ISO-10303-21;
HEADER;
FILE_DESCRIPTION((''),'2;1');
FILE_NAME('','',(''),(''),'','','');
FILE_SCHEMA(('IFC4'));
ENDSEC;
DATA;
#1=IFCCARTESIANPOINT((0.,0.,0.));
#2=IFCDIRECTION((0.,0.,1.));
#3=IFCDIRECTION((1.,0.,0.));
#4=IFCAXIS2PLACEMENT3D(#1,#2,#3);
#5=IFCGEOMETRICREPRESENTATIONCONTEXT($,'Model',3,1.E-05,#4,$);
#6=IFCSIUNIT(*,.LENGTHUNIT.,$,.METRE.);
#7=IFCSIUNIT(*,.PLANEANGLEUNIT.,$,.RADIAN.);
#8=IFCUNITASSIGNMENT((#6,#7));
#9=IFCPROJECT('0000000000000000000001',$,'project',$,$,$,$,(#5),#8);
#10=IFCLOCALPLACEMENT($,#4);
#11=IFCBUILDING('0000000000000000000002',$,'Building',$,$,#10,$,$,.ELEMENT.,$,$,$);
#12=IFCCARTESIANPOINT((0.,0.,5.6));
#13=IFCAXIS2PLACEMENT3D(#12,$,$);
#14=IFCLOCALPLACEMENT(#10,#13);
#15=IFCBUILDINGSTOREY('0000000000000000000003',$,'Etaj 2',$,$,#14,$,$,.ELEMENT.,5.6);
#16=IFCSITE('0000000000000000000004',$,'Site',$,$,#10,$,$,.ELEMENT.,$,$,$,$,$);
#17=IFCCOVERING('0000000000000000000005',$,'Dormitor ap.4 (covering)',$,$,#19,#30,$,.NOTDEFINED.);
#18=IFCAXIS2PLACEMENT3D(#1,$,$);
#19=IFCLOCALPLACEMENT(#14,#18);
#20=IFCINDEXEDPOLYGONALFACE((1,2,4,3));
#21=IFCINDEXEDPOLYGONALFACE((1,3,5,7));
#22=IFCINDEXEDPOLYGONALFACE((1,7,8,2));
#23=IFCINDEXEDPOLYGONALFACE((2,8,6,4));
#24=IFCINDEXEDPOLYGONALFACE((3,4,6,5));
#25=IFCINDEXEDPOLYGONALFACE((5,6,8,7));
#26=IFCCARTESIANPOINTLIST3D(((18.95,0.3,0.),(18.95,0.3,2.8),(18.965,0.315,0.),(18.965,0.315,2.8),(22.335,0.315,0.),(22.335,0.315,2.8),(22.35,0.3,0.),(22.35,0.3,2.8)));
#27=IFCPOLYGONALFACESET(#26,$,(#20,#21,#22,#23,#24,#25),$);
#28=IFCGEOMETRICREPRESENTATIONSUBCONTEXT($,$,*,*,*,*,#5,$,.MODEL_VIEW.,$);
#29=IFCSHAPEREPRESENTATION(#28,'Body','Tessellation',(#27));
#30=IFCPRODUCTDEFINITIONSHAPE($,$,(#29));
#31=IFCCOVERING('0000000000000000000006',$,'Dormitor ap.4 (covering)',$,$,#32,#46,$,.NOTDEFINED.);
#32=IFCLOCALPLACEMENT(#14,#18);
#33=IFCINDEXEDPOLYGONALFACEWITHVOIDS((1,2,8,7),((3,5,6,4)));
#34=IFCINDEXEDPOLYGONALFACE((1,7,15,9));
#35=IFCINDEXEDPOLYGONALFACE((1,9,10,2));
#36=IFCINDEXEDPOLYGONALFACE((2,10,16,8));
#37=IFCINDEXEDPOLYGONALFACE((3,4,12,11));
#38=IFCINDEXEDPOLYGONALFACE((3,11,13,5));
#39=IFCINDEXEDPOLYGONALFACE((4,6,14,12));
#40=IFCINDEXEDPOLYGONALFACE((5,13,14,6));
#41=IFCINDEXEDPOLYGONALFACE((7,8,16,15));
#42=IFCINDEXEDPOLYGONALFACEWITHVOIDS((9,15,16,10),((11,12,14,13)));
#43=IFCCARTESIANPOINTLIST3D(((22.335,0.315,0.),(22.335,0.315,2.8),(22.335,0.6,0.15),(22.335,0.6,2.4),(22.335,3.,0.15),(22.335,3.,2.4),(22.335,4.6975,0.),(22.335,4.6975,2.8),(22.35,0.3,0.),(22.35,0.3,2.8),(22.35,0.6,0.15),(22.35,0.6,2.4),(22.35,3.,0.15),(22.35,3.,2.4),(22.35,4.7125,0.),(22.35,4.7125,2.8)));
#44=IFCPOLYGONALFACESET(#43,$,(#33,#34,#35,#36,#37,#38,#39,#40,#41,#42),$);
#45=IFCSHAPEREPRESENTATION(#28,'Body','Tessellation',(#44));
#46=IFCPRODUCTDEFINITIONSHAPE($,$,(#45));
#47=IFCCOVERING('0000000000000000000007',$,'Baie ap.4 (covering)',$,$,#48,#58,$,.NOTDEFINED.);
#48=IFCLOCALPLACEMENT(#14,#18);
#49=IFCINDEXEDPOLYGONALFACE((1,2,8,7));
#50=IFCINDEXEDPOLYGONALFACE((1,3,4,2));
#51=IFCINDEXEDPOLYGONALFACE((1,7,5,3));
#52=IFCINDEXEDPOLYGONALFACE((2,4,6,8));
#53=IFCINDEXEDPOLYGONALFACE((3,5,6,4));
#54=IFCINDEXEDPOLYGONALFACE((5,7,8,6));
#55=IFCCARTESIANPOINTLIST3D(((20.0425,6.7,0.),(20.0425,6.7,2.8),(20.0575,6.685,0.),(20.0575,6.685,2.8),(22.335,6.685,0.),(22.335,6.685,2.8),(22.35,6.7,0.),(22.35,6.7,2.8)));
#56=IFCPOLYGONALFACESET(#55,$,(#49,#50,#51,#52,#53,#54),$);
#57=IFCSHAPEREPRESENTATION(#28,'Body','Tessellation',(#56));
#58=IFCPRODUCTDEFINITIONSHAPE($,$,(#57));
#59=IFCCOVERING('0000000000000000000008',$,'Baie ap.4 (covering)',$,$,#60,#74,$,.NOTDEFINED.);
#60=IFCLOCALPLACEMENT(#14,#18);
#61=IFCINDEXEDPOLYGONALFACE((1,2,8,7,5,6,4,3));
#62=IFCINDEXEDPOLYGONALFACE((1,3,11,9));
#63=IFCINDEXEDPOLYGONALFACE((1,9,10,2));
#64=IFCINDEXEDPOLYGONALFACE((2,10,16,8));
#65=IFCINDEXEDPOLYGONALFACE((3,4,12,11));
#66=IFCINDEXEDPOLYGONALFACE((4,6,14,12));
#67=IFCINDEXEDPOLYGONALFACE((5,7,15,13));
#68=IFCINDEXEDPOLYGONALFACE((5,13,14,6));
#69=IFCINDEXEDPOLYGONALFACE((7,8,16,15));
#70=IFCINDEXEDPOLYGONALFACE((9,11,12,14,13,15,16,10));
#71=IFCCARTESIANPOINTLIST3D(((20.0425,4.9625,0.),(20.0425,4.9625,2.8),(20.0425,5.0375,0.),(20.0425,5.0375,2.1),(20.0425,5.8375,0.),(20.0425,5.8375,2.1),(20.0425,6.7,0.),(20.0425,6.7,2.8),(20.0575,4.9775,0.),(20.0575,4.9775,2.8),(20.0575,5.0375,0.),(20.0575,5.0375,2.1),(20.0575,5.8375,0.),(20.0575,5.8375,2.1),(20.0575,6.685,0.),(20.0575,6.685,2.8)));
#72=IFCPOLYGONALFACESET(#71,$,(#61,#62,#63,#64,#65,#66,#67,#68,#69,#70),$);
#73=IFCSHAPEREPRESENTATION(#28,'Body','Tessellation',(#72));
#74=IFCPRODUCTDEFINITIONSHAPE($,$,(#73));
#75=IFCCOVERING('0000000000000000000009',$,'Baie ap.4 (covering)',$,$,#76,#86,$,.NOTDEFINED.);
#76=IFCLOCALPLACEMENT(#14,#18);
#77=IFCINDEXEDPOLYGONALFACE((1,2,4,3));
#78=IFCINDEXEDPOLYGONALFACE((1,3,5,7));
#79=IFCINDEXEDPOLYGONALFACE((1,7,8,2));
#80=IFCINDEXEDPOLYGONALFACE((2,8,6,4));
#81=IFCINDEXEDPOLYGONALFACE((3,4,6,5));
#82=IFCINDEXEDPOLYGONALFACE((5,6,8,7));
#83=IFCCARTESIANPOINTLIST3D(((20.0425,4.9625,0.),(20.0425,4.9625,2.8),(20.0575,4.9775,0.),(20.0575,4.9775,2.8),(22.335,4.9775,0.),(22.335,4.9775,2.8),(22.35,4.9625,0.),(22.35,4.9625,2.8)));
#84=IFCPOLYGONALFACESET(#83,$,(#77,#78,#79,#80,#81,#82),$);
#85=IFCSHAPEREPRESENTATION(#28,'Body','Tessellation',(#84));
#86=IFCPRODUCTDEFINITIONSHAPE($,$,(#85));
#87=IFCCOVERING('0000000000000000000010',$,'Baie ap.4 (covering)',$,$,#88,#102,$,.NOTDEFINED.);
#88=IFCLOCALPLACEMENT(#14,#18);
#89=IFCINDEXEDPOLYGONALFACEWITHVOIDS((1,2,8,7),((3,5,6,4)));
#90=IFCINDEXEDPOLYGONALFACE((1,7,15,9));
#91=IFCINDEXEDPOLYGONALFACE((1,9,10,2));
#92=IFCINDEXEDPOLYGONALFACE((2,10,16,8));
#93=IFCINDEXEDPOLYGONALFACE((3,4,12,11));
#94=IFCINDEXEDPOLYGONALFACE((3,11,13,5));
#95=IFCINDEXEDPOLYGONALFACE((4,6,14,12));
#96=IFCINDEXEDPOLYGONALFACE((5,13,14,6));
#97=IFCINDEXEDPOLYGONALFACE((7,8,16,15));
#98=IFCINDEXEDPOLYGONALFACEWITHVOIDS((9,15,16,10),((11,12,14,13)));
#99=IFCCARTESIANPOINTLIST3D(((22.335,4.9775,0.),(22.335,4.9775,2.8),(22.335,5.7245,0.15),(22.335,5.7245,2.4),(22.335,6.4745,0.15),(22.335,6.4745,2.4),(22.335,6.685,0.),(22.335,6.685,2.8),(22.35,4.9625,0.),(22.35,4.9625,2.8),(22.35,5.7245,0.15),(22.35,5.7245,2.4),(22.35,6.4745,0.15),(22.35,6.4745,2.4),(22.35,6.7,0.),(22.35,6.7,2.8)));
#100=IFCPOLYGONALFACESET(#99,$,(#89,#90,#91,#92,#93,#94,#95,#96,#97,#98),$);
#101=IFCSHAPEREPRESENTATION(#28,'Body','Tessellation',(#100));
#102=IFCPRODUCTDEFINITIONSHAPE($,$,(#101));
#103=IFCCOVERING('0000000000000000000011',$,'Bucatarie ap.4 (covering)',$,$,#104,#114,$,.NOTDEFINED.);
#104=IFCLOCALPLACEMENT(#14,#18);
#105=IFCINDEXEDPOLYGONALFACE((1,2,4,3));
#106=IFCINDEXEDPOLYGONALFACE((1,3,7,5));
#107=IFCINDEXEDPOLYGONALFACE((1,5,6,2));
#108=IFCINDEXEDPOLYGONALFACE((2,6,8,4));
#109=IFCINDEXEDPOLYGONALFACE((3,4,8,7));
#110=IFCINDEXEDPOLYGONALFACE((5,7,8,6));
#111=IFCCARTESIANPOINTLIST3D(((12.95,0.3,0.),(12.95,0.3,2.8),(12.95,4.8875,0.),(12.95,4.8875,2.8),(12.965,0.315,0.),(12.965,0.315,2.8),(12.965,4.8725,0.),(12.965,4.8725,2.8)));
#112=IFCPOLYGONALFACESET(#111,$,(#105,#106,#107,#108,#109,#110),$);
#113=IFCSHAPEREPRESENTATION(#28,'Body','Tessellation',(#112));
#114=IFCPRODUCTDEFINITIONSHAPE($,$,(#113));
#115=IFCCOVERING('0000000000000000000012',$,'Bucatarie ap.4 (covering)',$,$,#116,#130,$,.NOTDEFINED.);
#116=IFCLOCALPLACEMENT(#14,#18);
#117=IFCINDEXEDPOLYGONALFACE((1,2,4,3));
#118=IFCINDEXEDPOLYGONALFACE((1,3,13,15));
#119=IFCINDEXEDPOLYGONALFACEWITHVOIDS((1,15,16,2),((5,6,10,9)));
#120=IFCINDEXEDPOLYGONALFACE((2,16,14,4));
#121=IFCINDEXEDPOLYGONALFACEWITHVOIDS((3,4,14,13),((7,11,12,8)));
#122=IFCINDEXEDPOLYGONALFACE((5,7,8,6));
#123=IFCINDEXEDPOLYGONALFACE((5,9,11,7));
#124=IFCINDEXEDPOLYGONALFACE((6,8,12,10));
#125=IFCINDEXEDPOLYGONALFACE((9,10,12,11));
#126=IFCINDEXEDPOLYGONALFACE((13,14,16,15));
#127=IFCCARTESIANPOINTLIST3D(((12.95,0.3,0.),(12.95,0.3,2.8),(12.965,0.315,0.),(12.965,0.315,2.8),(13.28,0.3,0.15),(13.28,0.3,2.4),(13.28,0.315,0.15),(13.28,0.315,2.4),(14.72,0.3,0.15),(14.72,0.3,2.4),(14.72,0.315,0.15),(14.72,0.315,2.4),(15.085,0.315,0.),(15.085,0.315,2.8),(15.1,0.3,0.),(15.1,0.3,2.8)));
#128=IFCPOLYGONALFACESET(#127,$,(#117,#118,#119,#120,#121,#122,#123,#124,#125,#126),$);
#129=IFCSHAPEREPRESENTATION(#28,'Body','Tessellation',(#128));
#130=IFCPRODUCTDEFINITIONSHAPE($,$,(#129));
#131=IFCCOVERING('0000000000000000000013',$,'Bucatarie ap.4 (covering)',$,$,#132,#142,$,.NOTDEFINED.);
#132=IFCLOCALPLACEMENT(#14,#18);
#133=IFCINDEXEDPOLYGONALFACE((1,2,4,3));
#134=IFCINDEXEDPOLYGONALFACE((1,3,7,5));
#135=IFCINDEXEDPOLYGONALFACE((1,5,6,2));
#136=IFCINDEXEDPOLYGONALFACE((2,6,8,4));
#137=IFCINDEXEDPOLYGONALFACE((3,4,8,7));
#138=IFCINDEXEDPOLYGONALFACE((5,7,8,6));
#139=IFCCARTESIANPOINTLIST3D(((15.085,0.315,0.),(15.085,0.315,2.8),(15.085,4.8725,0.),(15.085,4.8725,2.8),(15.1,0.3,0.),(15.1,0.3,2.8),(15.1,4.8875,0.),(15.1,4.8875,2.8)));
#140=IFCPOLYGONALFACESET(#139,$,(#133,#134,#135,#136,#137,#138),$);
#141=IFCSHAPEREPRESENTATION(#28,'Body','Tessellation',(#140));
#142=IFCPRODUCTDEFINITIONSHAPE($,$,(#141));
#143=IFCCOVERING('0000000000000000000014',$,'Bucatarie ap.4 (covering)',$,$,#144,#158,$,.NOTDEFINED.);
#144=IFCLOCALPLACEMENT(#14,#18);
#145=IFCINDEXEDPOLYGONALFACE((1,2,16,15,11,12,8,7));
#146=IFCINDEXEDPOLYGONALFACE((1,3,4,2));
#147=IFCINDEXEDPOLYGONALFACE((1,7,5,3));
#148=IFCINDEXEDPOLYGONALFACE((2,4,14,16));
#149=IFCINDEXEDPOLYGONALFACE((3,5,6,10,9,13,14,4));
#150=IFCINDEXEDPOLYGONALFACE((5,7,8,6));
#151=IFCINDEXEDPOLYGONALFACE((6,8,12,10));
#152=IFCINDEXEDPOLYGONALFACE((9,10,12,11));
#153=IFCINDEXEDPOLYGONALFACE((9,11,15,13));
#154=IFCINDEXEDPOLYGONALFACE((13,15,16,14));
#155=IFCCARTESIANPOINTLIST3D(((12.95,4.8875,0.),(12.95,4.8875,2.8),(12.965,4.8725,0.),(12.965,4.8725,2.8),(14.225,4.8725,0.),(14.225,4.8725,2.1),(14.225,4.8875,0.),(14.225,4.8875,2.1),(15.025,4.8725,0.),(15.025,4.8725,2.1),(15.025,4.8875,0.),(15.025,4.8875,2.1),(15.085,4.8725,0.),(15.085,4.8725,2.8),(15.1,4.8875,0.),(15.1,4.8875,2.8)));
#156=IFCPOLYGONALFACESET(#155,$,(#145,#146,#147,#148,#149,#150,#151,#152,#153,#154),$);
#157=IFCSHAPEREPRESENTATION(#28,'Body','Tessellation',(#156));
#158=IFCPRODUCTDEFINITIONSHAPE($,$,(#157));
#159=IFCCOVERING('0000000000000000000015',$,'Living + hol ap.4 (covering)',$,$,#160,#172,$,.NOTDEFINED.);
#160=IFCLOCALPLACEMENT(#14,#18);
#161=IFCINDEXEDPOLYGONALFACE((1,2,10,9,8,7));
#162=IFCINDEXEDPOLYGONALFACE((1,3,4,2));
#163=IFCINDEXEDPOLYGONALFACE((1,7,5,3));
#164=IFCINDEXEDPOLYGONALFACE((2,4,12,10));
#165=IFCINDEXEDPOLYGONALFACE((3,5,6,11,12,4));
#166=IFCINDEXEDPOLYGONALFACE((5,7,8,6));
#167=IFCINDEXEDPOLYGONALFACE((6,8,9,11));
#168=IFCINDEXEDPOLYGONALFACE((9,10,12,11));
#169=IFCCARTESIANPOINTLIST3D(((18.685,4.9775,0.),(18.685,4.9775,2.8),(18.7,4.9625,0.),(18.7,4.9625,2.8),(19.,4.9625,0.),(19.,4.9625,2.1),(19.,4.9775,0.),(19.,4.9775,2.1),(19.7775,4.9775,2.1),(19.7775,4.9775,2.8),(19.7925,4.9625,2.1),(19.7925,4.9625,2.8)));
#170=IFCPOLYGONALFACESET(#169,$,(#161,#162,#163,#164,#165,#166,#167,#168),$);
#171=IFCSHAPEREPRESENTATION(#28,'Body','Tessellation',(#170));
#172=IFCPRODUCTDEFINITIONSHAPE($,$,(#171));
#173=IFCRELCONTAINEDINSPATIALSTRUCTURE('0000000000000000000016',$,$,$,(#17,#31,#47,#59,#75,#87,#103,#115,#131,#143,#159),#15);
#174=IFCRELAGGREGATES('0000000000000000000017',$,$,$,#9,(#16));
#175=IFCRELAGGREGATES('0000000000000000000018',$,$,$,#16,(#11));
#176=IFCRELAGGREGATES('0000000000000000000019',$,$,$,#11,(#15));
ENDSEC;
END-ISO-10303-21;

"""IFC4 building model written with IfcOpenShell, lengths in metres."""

from ifc_helpers import new_model, si_unit, frame, origin, origin_with_axes, origin_2d, place, context, subcontext, project, spatial, polyline, rectangle, outline, extrude, element, save


model = new_model("IFC4")

# Units and contexts
model_context = context("Model", 3, precision=1e-05, world=origin_with_axes())
sub_context = subcontext(model_context, None, None, "MODEL_VIEW")
ifc_project = project(units=[si_unit("LENGTHUNIT", "METRE"), si_unit("PLANEANGLEUNIT", "RADIAN")], contexts=[model_context])

# Site, building, storey
placement = place(None, origin_with_axes())
site = spatial("IfcSite", under=ifc_project, at=placement, Name="Site", CompositionType="ELEMENT")
building = spatial("IfcBuilding", under=site, at=placement, Name="Building", CompositionType="ELEMENT")
storey_placement = place(placement, frame((0.0, 0.0, 5.6)))
storey = spatial("IfcBuildingStorey", under=building, at=storey_placement, Name="Etaj 2", CompositionType="ELEMENT", Elevation=5.6)

# Covering
covering_1_placement = place(storey_placement, origin_with_axes())
element("IfcCovering", 1, at=covering_1_placement, inside=storey, Name="Dormitor ap.4 (covering)", PredefinedType="NOTDEFINED", context=sub_context, shape_type="SweptSolid", body=[
    extrude(outline(polyline([(18.95, 0.3), (22.35, 0.3), (22.335, 0.315), (18.965, 0.315), (18.95, 0.3)])), origin(), (0.0, 0.0, 1.0), 2.8),
])

# Covering, opening
covering_2_placement = place(storey_placement, origin_with_axes())
covering_2 = element("IfcCovering", 2, at=covering_2_placement, inside=storey, Name="Dormitor ap.4 (covering)", PredefinedType="NOTDEFINED", context=sub_context, shape_type="SweptSolid", body=[
    extrude(outline(polyline([(22.35, 0.3), (22.35, 4.7125), (22.335, 4.6975), (22.335, 0.315), (22.35, 0.3)])), origin(), (0.0, 0.0, 1.0), 2.8),
])
opening_1_placement = place(covering_2_placement, frame((22.285, 1.8, 0.15), z_axis=(1.0, 0.0, 0.0), x_axis=(0.0, 1.0, 0.0)))
element("IfcOpeningElement", 3, at=opening_1_placement, cuts=covering_2, PredefinedType="OPENING", context=sub_context, shape_type="SweptSolid", body=[
    extrude(rectangle(XDim=2.4, YDim=2.25, at=origin_2d()), frame((0.0, 1.125, 0.0)), (0.0, 0.0, 1.0), 0.38),
])

# Covering
covering_3_placement = place(storey_placement, origin_with_axes())
element("IfcCovering", 4, at=covering_3_placement, inside=storey, Name="Baie ap.4 (covering)", PredefinedType="NOTDEFINED", context=sub_context, shape_type="SweptSolid", body=[
    extrude(outline(polyline([(22.35, 6.7), (20.0425, 6.7), (20.0575, 6.685), (22.335, 6.685), (22.35, 6.7)])), origin(), (0.0, 0.0, 1.0), 2.8),
])

# Covering, opening
covering_4_placement = place(storey_placement, origin_with_axes())
covering_4 = element("IfcCovering", 5, at=covering_4_placement, inside=storey, Name="Baie ap.4 (covering)", PredefinedType="NOTDEFINED", context=sub_context, shape_type="SweptSolid", body=[
    extrude(outline(polyline([(20.0425, 6.7), (20.0425, 4.9625), (20.0575, 4.9775), (20.0575, 6.685), (20.0425, 6.7)])), origin(), (0.0, 0.0, 1.0), 2.8),
])
opening_2_placement = place(covering_4_placement, frame((19.7275, 5.4375, 0.0), z_axis=(1.0, 0.0, 0.0), x_axis=(0.0, 1.0, 0.0)))
element("IfcOpeningElement", 6, at=opening_2_placement, cuts=covering_4, PredefinedType="OPENING", context=sub_context, shape_type="SweptSolid", body=[
    extrude(rectangle(XDim=0.8, YDim=2.1, at=origin_2d()), frame((0.0, 1.05, 0.0)), (0.0, 0.0, 1.0), 0.38),
])

# Covering
covering_5_placement = place(storey_placement, origin_with_axes())
element("IfcCovering", 7, at=covering_5_placement, inside=storey, Name="Baie ap.4 (covering)", PredefinedType="NOTDEFINED", context=sub_context, shape_type="SweptSolid", body=[
    extrude(outline(polyline([(20.0425, 4.9625), (22.35, 4.9625), (22.335, 4.9775), (20.0575, 4.9775), (20.0425, 4.9625)])), origin(), (0.0, 0.0, 1.0), 2.8),
])

# Covering, opening
covering_6_placement = place(storey_placement, origin_with_axes())
covering_6 = element("IfcCovering", 8, at=covering_6_placement, inside=storey, Name="Baie ap.4 (covering)", PredefinedType="NOTDEFINED", context=sub_context, shape_type="SweptSolid", body=[
    extrude(outline(polyline([(22.35, 4.9625), (22.35, 6.7), (22.335, 6.685), (22.335, 4.9775), (22.35, 4.9625)])), origin(), (0.0, 0.0, 1.0), 2.8),
])
opening_3_placement = place(covering_6_placement, frame((22.285, 6.0995, 0.15), z_axis=(1.0, 0.0, 0.0), x_axis=(0.0, 1.0, 0.0)))
element("IfcOpeningElement", 9, at=opening_3_placement, cuts=covering_6, PredefinedType="OPENING", context=sub_context, shape_type="SweptSolid", body=[
    extrude(rectangle(XDim=0.75, YDim=2.25, at=origin_2d()), frame((0.0, 1.125, 0.0)), (0.0, 0.0, 1.0), 0.38),
])

# Covering
covering_7_placement = place(storey_placement, origin_with_axes())
element("IfcCovering", 10, at=covering_7_placement, inside=storey, Name="Bucatarie ap.4 (covering)", PredefinedType="NOTDEFINED", context=sub_context, shape_type="SweptSolid", body=[
    extrude(outline(polyline([(12.95, 4.8875), (12.95, 0.3), (12.965, 0.315), (12.965, 4.8725), (12.95, 4.8875)])), origin(), (0.0, 0.0, 1.0), 2.8),
])

# Covering, opening
covering_8_placement = place(storey_placement, origin_with_axes())
covering_8 = element("IfcCovering", 11, at=covering_8_placement, inside=storey, Name="Bucatarie ap.4 (covering)", PredefinedType="NOTDEFINED", context=sub_context, shape_type="SweptSolid", body=[
    extrude(outline(polyline([(12.95, 0.3), (15.1, 0.3), (15.085, 0.315), (12.965, 0.315), (12.95, 0.3)])), origin(), (0.0, 0.0, 1.0), 2.8),
])
opening_4_placement = place(covering_8_placement, frame((14.0, 0.365, 0.15), z_axis=(0.0, -1.0, 0.0), x_axis=(1.0, 0.0, 0.0)))
element("IfcOpeningElement", 12, at=opening_4_placement, cuts=covering_8, PredefinedType="OPENING", context=sub_context, shape_type="SweptSolid", body=[
    extrude(rectangle(XDim=1.44, YDim=2.25, at=origin_2d()), frame((0.0, 1.125, 0.0)), (0.0, 0.0, 1.0), 0.38),
])

# Covering
covering_9_placement = place(storey_placement, origin_with_axes())
element("IfcCovering", 13, at=covering_9_placement, inside=storey, Name="Bucatarie ap.4 (covering)", PredefinedType="NOTDEFINED", context=sub_context, shape_type="SweptSolid", body=[
    extrude(outline(polyline([(15.1, 0.3), (15.1, 4.8875), (15.085, 4.8725), (15.085, 0.315), (15.1, 0.3)])), origin(), (0.0, 0.0, 1.0), 2.8),
])

# Coverings, openings
covering_10_placement = place(storey_placement, origin_with_axes())
covering_10 = element("IfcCovering", 14, at=covering_10_placement, inside=storey, Name="Bucatarie ap.4 (covering)", PredefinedType="NOTDEFINED", context=sub_context, shape_type="SweptSolid", body=[
    extrude(outline(polyline([(15.1, 4.8875), (12.95, 4.8875), (12.965, 4.8725), (15.085, 4.8725), (15.1, 4.8875)])), origin(), (0.0, 0.0, 1.0), 2.8),
])
opening_5_placement = place(covering_10_placement, frame((14.625, 5.2025, 0.0), z_axis=(0.0, -1.0, 0.0), x_axis=(1.0, 0.0, 0.0)))
element("IfcOpeningElement", 15, at=opening_5_placement, cuts=covering_10, PredefinedType="OPENING", context=sub_context, shape_type="SweptSolid", body=[
    extrude(rectangle(XDim=0.8, YDim=2.1, at=origin_2d()), frame((0.0, 1.05, 0.0)), (0.0, 0.0, 1.0), 0.38),
])
covering_11_placement = place(storey_placement, origin_with_axes())
covering_11 = element("IfcCovering", 16, at=covering_11_placement, inside=storey, Name="Living + hol ap.4 (covering)", PredefinedType="NOTDEFINED", context=sub_context, shape_type="SweptSolid", body=[
    extrude(outline(polyline([(18.7, 4.9625), (19.7925, 4.9625), (19.7775, 4.9775), (18.685, 4.9775), (18.7, 4.9625)])), origin(), (0.0, 0.0, 1.0), 2.8),
])
opening_6_placement = place(covering_11_placement, frame((19.4, 5.0275, 0.0), z_axis=(0.0, -1.0, 0.0), x_axis=(1.0, 0.0, 0.0)))
element("IfcOpeningElement", 17, at=opening_6_placement, cuts=covering_11, PredefinedType="OPENING", context=sub_context, shape_type="SweptSolid", body=[
    extrude(rectangle(XDim=0.8, YDim=2.1, at=origin_2d()), frame((0.0, 1.05, 0.0)), (0.0, 0.0, 1.0), 0.38),
])

save(model, "model.ifc")
